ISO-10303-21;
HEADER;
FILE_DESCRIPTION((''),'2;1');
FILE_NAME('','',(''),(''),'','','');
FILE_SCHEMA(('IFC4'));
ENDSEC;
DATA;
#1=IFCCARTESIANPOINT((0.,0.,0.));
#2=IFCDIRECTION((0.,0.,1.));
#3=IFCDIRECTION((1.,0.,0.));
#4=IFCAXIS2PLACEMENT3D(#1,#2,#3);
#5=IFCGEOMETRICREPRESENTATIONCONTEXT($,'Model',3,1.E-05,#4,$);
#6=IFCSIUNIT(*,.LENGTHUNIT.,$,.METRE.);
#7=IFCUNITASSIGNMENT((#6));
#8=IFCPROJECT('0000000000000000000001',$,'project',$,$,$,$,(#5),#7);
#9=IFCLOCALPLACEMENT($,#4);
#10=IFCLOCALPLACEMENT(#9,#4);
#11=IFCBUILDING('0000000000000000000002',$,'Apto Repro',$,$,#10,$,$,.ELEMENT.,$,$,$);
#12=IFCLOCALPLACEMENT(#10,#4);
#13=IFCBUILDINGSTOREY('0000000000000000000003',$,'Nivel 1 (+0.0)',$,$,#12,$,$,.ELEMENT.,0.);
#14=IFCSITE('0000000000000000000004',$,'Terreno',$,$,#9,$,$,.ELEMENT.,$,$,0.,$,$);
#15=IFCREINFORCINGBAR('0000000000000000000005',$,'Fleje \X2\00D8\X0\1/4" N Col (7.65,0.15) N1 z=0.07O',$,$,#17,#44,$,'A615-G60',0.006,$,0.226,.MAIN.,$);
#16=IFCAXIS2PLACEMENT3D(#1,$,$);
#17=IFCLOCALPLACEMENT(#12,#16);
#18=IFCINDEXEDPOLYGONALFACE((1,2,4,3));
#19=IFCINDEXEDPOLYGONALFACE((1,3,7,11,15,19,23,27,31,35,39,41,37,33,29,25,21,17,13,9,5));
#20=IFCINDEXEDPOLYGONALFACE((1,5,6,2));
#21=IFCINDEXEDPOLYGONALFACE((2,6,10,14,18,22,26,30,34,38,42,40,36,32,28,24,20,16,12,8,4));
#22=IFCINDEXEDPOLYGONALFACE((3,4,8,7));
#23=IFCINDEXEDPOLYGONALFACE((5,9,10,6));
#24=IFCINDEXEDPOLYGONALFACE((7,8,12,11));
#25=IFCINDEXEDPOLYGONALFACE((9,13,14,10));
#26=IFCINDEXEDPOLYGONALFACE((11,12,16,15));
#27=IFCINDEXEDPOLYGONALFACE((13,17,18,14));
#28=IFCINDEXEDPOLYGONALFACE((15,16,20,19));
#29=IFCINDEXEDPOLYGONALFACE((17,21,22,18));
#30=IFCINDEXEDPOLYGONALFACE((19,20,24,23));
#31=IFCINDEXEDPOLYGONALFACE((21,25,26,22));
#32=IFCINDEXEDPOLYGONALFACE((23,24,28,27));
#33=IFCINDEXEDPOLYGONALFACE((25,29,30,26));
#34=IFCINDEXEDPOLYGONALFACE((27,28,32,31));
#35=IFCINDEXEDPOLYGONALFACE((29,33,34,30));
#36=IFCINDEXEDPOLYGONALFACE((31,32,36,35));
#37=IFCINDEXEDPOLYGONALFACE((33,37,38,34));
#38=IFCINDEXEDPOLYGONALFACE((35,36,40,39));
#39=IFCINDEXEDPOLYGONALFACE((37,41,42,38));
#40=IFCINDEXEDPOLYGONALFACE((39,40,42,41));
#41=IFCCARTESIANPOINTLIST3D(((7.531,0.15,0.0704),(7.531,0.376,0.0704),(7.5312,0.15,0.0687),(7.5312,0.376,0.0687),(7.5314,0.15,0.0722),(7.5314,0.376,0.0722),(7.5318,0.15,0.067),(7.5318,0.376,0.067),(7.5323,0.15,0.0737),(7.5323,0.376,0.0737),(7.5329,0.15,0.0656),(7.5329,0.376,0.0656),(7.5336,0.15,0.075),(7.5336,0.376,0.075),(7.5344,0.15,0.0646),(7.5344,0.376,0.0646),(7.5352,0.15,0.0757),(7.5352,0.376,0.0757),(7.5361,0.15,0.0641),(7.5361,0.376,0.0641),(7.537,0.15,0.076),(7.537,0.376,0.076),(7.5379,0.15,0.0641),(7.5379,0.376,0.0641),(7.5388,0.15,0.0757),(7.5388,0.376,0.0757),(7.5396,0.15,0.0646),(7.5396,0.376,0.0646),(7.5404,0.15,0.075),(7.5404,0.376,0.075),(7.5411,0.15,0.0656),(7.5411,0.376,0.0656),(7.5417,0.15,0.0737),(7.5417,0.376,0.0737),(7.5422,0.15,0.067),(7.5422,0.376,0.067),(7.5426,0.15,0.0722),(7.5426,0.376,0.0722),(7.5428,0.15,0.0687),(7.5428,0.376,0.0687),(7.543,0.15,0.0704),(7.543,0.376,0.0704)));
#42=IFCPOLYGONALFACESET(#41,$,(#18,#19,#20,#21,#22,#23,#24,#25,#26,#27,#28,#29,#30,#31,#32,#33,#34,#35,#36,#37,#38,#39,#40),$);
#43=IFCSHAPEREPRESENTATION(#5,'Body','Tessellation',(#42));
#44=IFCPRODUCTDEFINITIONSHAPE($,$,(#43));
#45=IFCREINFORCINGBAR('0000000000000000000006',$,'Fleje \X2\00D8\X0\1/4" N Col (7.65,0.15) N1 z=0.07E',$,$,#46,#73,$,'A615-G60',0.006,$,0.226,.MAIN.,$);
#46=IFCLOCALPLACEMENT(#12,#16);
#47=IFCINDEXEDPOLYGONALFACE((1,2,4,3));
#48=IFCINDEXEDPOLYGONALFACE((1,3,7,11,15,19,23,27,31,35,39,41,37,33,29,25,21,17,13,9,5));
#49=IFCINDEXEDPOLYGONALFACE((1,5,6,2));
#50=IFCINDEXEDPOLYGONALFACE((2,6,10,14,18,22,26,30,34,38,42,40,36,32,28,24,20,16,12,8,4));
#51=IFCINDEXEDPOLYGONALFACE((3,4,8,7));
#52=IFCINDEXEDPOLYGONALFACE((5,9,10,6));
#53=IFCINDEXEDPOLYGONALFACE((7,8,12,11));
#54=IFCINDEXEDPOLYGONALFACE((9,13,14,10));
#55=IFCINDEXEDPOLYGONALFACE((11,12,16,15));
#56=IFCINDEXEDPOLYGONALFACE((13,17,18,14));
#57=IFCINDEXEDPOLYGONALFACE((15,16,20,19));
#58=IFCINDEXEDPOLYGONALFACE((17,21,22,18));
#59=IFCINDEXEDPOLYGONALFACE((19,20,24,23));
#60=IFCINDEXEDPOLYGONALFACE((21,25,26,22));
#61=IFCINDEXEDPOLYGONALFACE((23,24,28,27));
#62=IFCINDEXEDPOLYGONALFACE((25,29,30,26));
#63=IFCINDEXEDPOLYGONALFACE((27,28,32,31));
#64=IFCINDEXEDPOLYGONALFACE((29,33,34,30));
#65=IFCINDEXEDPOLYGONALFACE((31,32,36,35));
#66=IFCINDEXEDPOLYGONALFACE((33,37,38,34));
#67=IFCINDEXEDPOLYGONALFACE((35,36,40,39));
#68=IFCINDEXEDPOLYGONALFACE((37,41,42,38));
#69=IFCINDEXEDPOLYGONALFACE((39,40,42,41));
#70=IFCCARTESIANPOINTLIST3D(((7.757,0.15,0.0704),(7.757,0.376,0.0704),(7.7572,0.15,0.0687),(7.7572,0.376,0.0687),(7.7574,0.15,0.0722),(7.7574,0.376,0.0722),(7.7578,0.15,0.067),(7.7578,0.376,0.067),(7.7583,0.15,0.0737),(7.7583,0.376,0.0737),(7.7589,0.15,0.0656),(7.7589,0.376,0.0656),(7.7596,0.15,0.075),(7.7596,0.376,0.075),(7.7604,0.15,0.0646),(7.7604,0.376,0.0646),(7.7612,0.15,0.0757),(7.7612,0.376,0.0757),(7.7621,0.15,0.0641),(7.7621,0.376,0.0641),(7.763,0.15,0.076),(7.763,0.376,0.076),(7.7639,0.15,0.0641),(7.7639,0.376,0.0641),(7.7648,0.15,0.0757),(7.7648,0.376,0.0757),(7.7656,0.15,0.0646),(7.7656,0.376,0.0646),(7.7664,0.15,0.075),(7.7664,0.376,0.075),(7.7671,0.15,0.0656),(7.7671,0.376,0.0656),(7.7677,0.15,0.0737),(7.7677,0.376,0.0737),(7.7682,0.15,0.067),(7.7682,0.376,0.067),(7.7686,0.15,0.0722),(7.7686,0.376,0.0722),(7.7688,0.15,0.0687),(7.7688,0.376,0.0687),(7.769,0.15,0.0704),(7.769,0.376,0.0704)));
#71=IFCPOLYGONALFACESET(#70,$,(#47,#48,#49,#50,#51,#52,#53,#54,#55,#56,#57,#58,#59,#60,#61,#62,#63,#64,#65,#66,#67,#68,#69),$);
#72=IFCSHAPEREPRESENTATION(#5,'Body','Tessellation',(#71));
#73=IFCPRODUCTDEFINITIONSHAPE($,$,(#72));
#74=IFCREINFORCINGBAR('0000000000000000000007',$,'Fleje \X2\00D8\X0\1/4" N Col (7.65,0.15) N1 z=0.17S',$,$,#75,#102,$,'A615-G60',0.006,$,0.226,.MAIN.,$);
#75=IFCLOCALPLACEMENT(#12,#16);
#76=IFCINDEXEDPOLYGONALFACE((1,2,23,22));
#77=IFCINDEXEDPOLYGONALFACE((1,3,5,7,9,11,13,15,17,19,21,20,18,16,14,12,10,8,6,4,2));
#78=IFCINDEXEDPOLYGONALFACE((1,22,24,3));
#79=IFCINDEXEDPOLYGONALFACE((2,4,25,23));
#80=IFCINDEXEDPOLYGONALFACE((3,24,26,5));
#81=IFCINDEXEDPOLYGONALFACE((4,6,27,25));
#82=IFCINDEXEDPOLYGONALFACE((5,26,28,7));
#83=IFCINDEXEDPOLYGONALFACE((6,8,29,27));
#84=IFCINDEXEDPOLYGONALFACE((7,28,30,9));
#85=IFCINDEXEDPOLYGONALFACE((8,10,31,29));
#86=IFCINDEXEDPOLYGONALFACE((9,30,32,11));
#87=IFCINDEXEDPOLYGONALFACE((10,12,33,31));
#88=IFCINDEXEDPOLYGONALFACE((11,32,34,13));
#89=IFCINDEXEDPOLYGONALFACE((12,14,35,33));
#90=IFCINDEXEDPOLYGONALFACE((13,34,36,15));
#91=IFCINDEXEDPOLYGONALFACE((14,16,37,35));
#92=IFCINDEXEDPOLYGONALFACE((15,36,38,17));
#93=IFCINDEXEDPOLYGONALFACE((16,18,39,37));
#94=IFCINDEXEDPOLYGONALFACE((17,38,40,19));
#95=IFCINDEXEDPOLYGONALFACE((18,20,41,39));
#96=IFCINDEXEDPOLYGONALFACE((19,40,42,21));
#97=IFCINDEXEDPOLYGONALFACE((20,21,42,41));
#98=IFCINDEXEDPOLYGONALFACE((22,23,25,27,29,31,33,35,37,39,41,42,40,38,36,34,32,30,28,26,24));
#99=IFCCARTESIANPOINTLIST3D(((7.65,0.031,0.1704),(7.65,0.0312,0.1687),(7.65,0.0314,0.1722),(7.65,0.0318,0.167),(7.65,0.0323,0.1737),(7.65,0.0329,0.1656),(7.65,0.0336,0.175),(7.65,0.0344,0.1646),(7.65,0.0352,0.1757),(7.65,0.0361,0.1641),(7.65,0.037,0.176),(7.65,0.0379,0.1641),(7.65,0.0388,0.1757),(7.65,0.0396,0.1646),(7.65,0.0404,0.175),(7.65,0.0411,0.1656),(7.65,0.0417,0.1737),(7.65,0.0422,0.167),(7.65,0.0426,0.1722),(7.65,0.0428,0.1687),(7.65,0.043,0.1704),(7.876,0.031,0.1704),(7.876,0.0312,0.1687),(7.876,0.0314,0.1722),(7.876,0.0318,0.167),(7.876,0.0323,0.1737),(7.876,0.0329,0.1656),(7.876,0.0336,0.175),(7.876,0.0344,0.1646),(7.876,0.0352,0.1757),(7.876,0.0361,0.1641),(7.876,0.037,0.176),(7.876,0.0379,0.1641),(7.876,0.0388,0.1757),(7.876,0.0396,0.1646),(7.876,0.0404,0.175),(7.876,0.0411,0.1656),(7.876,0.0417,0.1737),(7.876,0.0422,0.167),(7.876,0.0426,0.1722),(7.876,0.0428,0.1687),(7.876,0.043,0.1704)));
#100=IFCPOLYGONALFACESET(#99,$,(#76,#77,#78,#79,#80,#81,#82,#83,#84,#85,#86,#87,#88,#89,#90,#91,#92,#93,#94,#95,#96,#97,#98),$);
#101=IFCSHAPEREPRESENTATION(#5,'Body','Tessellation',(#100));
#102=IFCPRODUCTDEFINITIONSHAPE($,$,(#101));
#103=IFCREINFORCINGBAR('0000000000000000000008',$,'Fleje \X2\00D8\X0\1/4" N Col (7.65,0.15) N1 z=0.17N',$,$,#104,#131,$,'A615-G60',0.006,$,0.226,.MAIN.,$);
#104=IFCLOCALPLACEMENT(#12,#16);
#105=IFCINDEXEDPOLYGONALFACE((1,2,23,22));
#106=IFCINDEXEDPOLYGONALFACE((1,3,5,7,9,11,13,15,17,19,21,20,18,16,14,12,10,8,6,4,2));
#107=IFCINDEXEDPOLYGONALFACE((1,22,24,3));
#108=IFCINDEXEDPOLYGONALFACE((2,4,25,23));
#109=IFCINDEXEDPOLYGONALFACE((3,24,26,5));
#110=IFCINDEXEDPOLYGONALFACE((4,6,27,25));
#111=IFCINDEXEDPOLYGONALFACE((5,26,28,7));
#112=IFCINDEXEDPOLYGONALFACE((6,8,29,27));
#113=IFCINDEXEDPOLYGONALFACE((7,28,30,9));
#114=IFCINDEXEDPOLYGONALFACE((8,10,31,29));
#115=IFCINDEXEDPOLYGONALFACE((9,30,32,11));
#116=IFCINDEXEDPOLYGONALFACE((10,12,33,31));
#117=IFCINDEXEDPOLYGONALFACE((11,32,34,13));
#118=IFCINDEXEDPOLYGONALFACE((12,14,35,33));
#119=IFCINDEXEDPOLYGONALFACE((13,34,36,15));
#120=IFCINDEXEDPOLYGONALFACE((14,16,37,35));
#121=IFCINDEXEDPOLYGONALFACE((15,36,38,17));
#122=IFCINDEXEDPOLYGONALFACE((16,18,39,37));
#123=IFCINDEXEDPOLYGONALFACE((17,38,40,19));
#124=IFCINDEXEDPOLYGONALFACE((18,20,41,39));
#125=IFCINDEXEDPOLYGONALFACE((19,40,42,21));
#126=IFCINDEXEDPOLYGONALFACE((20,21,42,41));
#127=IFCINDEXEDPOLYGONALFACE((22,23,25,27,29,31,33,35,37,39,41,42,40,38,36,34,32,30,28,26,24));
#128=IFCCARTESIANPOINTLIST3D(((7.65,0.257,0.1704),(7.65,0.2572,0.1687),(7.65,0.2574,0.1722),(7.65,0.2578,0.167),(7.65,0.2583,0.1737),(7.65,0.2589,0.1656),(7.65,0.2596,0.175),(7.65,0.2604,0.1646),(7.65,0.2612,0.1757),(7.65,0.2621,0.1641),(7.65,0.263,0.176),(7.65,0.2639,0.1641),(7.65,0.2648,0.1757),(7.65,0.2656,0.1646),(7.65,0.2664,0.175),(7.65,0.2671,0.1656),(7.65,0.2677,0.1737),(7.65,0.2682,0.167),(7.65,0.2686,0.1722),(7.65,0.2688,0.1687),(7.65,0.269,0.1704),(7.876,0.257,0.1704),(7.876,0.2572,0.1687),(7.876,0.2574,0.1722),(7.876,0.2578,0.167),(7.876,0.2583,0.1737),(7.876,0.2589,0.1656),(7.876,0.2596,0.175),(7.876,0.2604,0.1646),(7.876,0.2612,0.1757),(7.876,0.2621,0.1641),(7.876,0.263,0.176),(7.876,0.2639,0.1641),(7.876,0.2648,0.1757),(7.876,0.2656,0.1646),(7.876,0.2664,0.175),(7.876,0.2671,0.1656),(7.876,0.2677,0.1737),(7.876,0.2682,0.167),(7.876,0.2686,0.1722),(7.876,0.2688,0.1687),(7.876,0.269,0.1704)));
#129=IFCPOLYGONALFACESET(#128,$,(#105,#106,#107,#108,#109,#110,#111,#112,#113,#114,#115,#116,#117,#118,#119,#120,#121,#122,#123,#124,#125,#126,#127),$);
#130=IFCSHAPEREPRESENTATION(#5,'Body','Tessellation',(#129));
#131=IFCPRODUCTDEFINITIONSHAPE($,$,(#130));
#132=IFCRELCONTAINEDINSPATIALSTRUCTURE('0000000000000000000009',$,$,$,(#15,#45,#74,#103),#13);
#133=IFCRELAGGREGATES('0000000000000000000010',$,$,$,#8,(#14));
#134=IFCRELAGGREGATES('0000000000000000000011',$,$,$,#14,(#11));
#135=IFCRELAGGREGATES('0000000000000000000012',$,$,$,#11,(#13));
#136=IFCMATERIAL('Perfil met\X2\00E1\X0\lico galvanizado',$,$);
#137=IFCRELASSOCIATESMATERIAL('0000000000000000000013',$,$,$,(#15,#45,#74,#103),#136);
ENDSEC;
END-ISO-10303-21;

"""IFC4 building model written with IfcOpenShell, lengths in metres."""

from ifc_helpers import new_model, si_unit, frame, origin_with_axes, origin_2d_with_axis, place, context, project, spatial, circle, extrude, material, element, save


model = new_model("IFC4")

# Units and contexts
model_context = context("Model", 3, precision=1e-05, world=origin_with_axes())
ifc_project = project(units=[si_unit("LENGTHUNIT", "METRE")], contexts=[model_context])

# Site, building, storey
site_placement = place(None, origin_with_axes())
site = spatial("IfcSite", under=ifc_project, at=site_placement, Name="Terreno", CompositionType="ELEMENT", RefElevation=0.0)
building_placement = place(site_placement, origin_with_axes())
building = spatial("IfcBuilding", under=site, at=building_placement, Name="Apto Repro", CompositionType="ELEMENT")
storey_placement = place(building_placement, origin_with_axes())
storey = spatial("IfcBuildingStorey", under=building, at=storey_placement, Name="Nivel 1 (+0.0)", CompositionType="ELEMENT", Elevation=0.0)

# Reinforcing bars
ifc_material = material(Name="Perfil metálico galvanizado")
reinforcing_bar_1_placement = place(storey_placement, origin_with_axes())
element("IfcReinforcingBar", 1, at=reinforcing_bar_1_placement, inside=storey, material=ifc_material, Name="Fleje Ø1/4\" N Col (7.65,0.15) N1 z=0.07O", SteelGrade="A615-G60", BarLength=0.226, NominalDiameter=0.006, PredefinedType="MAIN", context=model_context, shape_type="SweptSolid", body=[
    extrude(circle(Radius=0.006, at=origin_2d_with_axis()), frame((7.537, 0.15, 0.07), z_axis=(0.0, 1.0, 0.0), x_axis=(0.0, 0.0, 1.0)), (0.0, 0.0, 1.0), 0.226),
])
reinforcing_bar_2_placement = place(storey_placement, origin_with_axes())
element("IfcReinforcingBar", 2, at=reinforcing_bar_2_placement, inside=storey, material=ifc_material, Name="Fleje Ø1/4\" N Col (7.65,0.15) N1 z=0.07E", SteelGrade="A615-G60", BarLength=0.226, NominalDiameter=0.006, PredefinedType="MAIN", context=model_context, shape_type="SweptSolid", body=[
    extrude(circle(Radius=0.006, at=origin_2d_with_axis()), frame((7.763, 0.15, 0.07), z_axis=(0.0, 1.0, 0.0), x_axis=(0.0, 0.0, 1.0)), (0.0, 0.0, 1.0), 0.226),
])
reinforcing_bar_3_placement = place(storey_placement, origin_with_axes())
element("IfcReinforcingBar", 3, at=reinforcing_bar_3_placement, inside=storey, material=ifc_material, Name="Fleje Ø1/4\" N Col (7.65,0.15) N1 z=0.17S", SteelGrade="A615-G60", BarLength=0.226, NominalDiameter=0.006, PredefinedType="MAIN", context=model_context, shape_type="SweptSolid", body=[
    extrude(circle(Radius=0.006, at=origin_2d_with_axis()), frame((7.65, 0.037, 0.17), z_axis=(1.0, 0.0, 0.0), x_axis=(0.0, 0.0, 1.0)), (0.0, 0.0, 1.0), 0.226),
])
reinforcing_bar_4_placement = place(storey_placement, origin_with_axes())
element("IfcReinforcingBar", 4, at=reinforcing_bar_4_placement, inside=storey, material=ifc_material, Name="Fleje Ø1/4\" N Col (7.65,0.15) N1 z=0.17N", SteelGrade="A615-G60", BarLength=0.226, NominalDiameter=0.006, PredefinedType="MAIN", context=model_context, shape_type="SweptSolid", body=[
    extrude(circle(Radius=0.006, at=origin_2d_with_axis()), frame((7.65, 0.263, 0.17), z_axis=(1.0, 0.0, 0.0), x_axis=(0.0, 0.0, 1.0)), (0.0, 0.0, 1.0), 0.226),
])

save(model, "model.ifc")
